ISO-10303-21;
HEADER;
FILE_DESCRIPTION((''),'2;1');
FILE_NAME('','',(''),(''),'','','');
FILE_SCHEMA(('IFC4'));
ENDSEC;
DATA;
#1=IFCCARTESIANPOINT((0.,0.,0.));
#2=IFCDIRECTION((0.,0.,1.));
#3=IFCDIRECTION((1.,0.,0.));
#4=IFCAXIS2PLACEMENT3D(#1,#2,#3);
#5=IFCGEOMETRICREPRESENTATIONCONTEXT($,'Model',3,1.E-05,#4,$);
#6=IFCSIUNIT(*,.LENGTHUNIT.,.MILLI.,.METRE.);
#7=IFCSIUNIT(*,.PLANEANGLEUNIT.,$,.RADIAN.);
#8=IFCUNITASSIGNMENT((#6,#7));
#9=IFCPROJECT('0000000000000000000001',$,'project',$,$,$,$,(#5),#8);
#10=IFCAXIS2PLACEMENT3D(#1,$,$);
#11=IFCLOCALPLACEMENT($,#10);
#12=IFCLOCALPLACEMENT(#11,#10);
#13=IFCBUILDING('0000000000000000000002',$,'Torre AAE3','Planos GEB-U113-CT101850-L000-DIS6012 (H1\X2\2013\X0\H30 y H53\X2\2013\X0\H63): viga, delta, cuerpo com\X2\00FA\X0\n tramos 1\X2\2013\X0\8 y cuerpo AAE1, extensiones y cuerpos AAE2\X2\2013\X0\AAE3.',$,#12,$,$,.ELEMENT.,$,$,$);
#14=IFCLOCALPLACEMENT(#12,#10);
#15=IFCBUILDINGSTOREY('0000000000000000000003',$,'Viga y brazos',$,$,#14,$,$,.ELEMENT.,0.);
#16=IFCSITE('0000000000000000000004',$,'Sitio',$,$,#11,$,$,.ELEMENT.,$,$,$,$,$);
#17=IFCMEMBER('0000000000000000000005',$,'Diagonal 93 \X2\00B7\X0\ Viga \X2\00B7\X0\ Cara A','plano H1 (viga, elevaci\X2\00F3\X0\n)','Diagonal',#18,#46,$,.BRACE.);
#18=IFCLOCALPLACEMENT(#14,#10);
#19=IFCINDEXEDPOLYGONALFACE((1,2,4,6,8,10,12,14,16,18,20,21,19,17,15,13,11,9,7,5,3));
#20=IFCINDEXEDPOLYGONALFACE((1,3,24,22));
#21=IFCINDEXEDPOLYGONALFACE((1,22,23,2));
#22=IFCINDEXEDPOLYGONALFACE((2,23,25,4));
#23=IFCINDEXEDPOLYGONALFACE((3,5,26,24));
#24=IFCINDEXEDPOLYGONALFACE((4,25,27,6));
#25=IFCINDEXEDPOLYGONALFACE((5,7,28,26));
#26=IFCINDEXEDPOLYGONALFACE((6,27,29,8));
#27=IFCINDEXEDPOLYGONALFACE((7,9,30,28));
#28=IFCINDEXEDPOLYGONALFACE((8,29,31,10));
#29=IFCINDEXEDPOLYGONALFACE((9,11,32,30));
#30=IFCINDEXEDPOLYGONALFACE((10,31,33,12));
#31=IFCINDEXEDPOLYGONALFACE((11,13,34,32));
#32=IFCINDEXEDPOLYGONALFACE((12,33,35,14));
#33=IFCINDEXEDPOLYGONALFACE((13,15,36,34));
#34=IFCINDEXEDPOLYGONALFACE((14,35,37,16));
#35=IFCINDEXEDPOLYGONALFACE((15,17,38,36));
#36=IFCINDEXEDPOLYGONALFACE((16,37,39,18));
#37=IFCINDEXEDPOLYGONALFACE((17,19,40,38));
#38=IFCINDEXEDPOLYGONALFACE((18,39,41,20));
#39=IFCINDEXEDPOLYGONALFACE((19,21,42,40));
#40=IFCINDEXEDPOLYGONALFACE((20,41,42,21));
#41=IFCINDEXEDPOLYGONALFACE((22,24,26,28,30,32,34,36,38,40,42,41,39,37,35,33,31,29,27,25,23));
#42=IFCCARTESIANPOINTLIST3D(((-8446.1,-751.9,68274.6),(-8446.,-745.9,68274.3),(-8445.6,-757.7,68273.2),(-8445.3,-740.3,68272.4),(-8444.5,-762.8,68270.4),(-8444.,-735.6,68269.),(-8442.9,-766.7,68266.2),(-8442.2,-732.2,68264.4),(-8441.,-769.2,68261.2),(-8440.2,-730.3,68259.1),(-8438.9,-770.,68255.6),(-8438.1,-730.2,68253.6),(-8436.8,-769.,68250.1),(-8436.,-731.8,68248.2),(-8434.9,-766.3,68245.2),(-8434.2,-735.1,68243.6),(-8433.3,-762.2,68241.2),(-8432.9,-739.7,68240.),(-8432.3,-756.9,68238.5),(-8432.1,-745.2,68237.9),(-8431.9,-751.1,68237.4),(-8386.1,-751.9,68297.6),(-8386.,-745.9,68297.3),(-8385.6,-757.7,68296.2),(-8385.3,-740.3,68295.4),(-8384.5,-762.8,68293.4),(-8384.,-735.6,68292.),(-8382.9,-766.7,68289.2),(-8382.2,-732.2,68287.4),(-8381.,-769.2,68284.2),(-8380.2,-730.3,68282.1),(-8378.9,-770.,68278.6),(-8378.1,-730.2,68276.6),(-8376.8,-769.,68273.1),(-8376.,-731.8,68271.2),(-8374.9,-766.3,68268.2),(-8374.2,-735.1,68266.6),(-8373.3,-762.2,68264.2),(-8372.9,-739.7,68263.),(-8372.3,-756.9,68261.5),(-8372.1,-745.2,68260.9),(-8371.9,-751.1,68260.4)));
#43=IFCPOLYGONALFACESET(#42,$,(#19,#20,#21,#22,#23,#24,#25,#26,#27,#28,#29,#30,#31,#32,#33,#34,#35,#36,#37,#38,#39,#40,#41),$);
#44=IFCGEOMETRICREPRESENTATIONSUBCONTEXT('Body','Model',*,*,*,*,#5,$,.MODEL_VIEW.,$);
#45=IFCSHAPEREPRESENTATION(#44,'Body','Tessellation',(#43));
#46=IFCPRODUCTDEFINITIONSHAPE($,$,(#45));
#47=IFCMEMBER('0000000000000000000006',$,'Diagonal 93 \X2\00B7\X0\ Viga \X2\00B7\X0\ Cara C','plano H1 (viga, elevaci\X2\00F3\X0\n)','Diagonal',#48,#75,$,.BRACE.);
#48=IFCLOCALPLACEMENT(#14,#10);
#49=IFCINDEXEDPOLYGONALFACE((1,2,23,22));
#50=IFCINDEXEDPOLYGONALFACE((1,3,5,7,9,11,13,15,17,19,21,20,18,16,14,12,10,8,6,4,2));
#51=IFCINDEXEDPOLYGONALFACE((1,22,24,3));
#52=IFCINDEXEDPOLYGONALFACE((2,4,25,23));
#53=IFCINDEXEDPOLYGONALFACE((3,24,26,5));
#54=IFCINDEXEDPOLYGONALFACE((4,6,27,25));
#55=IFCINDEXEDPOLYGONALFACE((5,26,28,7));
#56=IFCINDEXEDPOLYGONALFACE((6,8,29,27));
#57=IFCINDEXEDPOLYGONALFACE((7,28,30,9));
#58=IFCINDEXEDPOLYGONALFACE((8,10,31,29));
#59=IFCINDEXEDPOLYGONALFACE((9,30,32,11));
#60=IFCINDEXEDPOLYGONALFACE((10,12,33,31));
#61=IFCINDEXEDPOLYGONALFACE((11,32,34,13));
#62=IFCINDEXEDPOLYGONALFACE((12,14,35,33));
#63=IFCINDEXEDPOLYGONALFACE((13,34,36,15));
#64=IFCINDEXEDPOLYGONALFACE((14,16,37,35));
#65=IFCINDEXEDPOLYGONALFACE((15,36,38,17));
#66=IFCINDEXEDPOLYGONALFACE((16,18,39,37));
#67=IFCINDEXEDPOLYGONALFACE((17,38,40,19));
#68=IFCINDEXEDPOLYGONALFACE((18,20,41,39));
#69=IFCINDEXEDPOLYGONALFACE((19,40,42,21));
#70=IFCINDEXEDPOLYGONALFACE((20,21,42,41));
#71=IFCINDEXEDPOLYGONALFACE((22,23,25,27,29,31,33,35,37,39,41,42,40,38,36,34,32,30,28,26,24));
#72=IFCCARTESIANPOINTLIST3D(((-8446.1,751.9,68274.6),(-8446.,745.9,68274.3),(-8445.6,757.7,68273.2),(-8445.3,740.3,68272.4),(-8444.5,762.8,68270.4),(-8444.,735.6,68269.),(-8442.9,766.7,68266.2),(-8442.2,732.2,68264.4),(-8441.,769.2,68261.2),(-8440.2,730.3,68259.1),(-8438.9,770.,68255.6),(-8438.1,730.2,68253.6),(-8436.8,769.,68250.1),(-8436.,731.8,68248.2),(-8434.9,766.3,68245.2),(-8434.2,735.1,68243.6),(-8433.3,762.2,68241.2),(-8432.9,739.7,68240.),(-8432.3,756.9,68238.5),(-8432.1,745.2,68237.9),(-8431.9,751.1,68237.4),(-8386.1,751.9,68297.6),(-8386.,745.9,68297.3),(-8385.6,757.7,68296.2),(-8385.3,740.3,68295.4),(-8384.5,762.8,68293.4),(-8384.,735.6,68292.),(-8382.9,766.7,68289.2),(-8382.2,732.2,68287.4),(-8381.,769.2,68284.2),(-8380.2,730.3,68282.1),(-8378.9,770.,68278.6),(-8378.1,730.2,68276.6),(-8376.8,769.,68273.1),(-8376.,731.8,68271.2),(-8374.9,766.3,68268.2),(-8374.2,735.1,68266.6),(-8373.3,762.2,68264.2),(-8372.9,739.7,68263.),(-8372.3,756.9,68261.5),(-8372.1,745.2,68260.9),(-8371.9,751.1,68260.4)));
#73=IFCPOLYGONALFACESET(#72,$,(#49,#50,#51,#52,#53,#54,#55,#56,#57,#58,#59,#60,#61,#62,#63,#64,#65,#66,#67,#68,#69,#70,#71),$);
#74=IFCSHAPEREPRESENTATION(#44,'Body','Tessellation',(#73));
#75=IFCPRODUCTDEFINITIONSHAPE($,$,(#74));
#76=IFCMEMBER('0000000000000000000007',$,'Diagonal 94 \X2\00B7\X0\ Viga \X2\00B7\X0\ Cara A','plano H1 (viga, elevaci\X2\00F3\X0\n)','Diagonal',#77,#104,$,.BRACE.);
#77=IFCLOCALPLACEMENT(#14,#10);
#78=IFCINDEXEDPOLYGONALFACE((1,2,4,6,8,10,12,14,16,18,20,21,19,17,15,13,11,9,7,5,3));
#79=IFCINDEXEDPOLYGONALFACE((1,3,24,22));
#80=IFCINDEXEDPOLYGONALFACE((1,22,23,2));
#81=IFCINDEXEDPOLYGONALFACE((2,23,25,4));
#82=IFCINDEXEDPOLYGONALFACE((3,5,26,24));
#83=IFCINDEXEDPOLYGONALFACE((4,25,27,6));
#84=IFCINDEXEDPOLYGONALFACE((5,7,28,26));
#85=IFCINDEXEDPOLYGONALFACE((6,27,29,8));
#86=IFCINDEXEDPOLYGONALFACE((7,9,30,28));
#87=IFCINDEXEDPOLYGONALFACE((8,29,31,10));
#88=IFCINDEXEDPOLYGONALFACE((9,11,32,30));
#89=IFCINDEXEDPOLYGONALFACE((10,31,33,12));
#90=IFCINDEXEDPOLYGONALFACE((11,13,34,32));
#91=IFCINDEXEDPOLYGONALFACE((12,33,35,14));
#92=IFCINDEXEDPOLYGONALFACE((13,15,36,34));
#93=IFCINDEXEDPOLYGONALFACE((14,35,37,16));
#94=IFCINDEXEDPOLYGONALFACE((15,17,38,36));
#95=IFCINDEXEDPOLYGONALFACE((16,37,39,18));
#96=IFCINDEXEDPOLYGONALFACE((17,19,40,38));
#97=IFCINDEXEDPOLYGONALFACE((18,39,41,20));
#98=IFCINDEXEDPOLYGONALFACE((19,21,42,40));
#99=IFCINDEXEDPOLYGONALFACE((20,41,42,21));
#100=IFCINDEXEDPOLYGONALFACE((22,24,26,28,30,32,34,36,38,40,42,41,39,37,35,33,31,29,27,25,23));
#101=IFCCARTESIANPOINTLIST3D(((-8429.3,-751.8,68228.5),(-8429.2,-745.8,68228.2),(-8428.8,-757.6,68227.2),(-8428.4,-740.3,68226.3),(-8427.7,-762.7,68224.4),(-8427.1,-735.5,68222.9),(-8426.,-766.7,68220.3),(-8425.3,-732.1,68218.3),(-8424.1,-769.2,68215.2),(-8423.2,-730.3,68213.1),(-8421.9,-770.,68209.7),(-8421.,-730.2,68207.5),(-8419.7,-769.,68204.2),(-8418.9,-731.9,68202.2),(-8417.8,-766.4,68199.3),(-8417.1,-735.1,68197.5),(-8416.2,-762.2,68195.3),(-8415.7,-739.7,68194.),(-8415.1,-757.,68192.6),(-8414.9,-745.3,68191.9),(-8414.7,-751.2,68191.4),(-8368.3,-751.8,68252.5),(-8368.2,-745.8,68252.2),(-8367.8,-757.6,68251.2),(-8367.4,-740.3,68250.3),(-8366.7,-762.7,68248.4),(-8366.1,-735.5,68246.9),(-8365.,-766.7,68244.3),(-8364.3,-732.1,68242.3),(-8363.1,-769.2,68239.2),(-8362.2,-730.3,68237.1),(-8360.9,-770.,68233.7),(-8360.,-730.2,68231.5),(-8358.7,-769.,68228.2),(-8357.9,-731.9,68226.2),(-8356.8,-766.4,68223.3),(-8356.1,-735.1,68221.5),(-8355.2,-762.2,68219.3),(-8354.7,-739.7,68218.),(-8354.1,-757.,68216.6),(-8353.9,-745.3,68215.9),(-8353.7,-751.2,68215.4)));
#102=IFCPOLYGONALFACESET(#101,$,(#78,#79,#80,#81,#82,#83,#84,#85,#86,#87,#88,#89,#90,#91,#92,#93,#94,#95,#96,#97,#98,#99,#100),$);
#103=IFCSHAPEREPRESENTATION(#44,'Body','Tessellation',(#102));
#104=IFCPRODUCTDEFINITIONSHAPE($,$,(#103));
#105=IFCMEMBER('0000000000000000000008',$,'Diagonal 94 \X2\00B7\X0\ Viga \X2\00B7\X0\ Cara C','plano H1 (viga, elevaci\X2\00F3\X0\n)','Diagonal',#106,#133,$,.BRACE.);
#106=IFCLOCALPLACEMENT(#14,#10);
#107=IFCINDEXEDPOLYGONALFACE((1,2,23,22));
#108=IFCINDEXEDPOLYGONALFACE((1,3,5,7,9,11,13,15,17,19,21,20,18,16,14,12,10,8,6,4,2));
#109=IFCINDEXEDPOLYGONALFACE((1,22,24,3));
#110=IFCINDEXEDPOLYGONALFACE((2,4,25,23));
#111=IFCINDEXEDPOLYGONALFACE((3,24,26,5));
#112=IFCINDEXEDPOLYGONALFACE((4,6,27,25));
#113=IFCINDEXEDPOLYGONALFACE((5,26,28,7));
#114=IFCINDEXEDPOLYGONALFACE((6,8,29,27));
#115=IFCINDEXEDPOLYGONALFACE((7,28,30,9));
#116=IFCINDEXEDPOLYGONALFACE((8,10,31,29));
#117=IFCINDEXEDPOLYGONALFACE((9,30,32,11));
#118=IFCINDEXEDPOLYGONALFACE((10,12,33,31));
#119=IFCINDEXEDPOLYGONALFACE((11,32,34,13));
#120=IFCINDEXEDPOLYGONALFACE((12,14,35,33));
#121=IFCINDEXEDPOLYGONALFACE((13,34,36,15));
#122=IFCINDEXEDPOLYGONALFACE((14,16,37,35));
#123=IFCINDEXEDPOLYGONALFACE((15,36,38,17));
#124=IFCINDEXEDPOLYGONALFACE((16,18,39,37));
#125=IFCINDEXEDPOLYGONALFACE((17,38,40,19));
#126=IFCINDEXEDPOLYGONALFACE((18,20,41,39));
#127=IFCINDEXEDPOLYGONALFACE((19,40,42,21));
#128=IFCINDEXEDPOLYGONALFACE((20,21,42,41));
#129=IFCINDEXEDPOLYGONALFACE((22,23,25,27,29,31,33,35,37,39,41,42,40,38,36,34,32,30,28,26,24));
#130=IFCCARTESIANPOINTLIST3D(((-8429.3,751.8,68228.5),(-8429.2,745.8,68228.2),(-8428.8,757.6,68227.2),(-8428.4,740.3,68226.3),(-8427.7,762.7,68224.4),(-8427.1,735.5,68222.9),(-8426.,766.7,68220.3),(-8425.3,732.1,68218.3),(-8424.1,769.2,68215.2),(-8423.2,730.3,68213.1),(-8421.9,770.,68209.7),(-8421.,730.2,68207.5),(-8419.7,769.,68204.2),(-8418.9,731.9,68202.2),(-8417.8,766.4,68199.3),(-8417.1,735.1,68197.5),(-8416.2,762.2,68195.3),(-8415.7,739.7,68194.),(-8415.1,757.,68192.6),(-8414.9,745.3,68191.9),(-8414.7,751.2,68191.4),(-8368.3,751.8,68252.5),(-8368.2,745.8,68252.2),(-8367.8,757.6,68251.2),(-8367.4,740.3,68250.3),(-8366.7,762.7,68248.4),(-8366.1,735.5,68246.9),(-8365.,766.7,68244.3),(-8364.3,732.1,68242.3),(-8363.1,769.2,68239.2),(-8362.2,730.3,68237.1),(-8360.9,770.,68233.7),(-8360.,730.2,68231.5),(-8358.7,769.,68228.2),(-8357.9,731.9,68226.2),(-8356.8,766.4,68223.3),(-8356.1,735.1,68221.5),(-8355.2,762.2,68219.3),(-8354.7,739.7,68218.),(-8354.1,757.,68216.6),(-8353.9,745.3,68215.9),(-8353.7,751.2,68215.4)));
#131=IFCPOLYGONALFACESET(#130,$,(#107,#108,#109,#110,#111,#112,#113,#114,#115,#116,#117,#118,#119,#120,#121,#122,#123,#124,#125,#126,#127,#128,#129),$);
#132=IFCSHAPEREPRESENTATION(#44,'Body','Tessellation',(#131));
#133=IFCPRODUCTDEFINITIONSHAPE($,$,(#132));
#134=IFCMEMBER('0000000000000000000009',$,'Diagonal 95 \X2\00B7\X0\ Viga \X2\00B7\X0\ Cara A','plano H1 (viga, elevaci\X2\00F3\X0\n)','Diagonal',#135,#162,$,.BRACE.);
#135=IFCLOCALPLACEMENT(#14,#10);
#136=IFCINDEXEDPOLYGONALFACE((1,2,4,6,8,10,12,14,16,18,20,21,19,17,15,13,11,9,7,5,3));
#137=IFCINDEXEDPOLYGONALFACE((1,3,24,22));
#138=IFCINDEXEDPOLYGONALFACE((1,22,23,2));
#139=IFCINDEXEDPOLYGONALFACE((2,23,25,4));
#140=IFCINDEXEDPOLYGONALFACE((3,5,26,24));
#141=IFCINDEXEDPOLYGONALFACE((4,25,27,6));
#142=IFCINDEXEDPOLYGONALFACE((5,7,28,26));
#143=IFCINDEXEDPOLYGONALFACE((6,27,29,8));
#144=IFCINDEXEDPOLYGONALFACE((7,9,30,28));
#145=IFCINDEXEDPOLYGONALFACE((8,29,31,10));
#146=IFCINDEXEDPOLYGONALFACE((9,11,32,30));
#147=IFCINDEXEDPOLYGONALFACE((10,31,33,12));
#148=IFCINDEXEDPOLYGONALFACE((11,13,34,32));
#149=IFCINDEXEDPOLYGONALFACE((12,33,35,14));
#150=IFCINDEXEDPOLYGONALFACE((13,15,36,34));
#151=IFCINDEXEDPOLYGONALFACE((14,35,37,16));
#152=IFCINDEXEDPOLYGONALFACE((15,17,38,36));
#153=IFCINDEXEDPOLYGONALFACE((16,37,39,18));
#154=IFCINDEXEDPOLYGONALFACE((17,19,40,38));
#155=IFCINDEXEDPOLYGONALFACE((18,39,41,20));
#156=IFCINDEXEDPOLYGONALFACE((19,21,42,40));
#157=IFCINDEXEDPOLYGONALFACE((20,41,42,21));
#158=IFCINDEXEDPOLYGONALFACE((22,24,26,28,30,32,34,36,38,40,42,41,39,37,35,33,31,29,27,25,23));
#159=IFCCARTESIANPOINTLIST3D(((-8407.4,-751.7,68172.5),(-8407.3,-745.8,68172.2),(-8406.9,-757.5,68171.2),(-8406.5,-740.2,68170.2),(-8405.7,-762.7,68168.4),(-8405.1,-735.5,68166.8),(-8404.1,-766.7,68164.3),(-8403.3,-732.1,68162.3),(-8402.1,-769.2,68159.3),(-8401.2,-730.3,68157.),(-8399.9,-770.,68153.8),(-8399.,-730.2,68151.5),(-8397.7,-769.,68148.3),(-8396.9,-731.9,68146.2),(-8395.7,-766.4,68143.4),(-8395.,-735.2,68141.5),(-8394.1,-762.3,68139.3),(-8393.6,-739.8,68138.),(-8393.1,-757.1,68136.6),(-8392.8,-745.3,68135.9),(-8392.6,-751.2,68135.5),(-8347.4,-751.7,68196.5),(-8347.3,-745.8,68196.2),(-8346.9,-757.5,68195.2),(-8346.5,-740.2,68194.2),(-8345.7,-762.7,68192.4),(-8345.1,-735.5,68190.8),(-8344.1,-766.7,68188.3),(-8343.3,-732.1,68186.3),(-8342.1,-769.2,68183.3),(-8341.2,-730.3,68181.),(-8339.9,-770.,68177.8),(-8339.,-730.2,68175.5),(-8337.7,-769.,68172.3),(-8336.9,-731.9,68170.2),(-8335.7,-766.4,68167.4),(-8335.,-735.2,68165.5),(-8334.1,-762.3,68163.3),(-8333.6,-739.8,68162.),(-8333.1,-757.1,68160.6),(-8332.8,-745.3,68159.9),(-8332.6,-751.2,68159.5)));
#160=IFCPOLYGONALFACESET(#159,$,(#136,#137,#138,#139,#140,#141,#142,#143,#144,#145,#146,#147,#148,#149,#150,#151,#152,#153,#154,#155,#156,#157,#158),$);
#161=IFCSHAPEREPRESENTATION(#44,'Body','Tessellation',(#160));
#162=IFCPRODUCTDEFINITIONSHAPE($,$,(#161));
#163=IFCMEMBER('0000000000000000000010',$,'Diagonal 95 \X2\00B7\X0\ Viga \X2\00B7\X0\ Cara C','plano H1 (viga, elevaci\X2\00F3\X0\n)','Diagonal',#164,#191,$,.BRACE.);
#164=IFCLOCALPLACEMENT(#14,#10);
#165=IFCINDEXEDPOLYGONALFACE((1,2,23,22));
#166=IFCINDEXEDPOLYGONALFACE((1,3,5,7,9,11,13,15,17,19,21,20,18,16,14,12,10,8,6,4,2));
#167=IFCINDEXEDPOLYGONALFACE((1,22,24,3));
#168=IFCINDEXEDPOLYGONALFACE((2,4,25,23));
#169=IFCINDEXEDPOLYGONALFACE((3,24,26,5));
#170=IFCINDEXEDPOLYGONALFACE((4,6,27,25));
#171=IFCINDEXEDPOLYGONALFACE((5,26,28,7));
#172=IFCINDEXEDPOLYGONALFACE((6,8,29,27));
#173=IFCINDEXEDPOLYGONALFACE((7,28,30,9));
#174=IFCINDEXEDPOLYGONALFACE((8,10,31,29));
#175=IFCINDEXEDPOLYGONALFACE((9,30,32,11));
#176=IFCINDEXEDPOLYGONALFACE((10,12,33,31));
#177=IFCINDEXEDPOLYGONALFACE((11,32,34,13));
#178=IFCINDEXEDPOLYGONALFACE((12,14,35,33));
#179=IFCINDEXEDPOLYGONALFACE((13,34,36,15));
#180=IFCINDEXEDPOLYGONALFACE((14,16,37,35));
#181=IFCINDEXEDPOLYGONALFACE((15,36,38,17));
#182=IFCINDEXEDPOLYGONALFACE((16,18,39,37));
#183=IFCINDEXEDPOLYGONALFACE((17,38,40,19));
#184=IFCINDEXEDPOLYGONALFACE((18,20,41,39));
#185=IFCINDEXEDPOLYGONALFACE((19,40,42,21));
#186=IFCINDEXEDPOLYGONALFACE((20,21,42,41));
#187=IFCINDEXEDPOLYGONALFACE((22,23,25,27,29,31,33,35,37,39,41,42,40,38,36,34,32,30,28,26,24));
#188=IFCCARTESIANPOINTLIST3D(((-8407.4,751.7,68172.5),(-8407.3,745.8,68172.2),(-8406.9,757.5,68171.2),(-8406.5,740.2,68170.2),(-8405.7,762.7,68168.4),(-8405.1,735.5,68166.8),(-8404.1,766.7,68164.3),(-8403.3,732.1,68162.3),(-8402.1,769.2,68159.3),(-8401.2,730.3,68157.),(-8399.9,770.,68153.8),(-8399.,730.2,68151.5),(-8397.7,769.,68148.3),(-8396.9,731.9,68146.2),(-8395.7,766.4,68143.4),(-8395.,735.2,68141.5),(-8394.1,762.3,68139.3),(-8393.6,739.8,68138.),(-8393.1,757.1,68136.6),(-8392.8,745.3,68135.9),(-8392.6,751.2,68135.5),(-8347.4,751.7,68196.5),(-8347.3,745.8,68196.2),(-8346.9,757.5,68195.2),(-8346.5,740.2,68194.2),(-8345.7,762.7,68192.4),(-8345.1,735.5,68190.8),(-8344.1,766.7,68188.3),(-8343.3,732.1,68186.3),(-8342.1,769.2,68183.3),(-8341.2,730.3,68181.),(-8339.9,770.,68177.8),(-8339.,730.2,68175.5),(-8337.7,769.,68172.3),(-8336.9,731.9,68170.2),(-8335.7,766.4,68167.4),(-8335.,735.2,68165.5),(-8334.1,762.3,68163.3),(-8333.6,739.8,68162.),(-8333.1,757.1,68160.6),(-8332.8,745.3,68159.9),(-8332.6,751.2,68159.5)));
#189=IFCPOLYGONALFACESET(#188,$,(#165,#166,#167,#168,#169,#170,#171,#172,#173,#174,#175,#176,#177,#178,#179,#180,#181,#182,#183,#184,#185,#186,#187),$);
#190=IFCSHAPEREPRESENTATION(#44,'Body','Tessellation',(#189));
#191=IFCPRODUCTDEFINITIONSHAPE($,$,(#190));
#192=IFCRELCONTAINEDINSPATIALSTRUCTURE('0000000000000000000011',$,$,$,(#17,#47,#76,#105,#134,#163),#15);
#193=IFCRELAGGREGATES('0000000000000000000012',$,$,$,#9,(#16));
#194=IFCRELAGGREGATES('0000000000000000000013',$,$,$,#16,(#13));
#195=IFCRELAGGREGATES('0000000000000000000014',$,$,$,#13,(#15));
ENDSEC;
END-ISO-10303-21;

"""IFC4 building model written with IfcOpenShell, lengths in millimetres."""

from ifc_helpers import new_model, si_unit, frame, origin, origin_with_axes, place, context, subcontext, project, spatial, circle, extrude, element, save


model = new_model("IFC4")

# Units and contexts
model_context = context("Model", 3, precision=1e-05, world=origin_with_axes())
body_context = subcontext(model_context, "Body", "Model", "MODEL_VIEW")
ifc_project = project(units=[si_unit("LENGTHUNIT", "METRE", prefix="MILLI"), si_unit("PLANEANGLEUNIT", "RADIAN")], contexts=[model_context])

# Site, building, storey
site_placement = place(None, origin())
site = spatial("IfcSite", under=ifc_project, at=site_placement, Name="Sitio", CompositionType="ELEMENT")
building_placement = place(site_placement, origin())
building = spatial("IfcBuilding", under=site, at=building_placement, Name="Torre AAE3", Description="Planos GEB-U113-CT101850-L000-DIS6012 (H1–H30 y H53–H63): viga, delta, cuerpo común tramos 1–8 y cuerpo AAE1, extensiones y cuerpos AAE2–AAE3.", CompositionType="ELEMENT")
storey_placement = place(building_placement, origin())
storey = spatial("IfcBuildingStorey", under=building, at=storey_placement, Name="Viga y brazos", CompositionType="ELEMENT", Elevation=0.0)

# Members
for number, where, z_axis, x_axis, name in (
    (1, (-8379.0, -750.0, 68279.0), (-0.933746, 0.0, -0.357936), (0.347316, 0.241786, -0.906042), "Diagonal 93 · Viga · Cara A"),
    (2, (-8379.0, 750.0, 68279.0), (-0.933746, 0.0, -0.357936), (0.347316, -0.241786, -0.906042), "Diagonal 93 · Viga · Cara C"),
):
    element("IfcMember", number, at=place(storey_placement, frame(where, z_axis=z_axis, x_axis=x_axis)), inside=storey, Name=name, Description="plano H1 (viga, elevación)", ObjectType="Diagonal", PredefinedType="BRACE", context=body_context, shape_type="SweptSolid", body=[
        extrude(circle(Radius=20.0), None, (0.0, 0.0, 1.0), 64.3),
    ])
for number, where, z_axis, x_axis, name in (
    (3, (-8361.0, -750.0, 68234.0), (-0.930566, 0.0, -0.366124), (0.35568, 0.23715, -0.90402), "Diagonal 94 · Viga · Cara A"),
    (4, (-8361.0, 750.0, 68234.0), (-0.930566, 0.0, -0.366124), (0.35568, -0.23715, -0.90402), "Diagonal 94 · Viga · Cara C"),
):
    element("IfcMember", number, at=place(storey_placement, frame(where, z_axis=z_axis, x_axis=x_axis)), inside=storey, Name=name, Description="plano H1 (viga, elevación)", ObjectType="Diagonal", PredefinedType="BRACE", context=body_context, shape_type="SweptSolid", body=[
        extrude(circle(Radius=20.0), None, (0.0, 0.0, 1.0), 65.6),
    ])
for number, where, z_axis, x_axis, name in (
    (5, (-8340.0, -750.0, 68178.0), (-0.928477, 0.0, -0.371391), (0.361031, 0.234541, -0.902578), "Diagonal 95 · Viga · Cara A"),
    (6, (-8340.0, 750.0, 68178.0), (-0.928477, 0.0, -0.371391), (0.361031, -0.234541, -0.902578), "Diagonal 95 · Viga · Cara C"),
):
    element("IfcMember", number, at=place(storey_placement, frame(where, z_axis=z_axis, x_axis=x_axis)), inside=storey, Name=name, Description="plano H1 (viga, elevación)", ObjectType="Diagonal", PredefinedType="BRACE", context=body_context, shape_type="SweptSolid", body=[
        extrude(circle(Radius=20.0), None, (0.0, 0.0, 1.0), 64.6),
    ])

save(model, "model.ifc")
